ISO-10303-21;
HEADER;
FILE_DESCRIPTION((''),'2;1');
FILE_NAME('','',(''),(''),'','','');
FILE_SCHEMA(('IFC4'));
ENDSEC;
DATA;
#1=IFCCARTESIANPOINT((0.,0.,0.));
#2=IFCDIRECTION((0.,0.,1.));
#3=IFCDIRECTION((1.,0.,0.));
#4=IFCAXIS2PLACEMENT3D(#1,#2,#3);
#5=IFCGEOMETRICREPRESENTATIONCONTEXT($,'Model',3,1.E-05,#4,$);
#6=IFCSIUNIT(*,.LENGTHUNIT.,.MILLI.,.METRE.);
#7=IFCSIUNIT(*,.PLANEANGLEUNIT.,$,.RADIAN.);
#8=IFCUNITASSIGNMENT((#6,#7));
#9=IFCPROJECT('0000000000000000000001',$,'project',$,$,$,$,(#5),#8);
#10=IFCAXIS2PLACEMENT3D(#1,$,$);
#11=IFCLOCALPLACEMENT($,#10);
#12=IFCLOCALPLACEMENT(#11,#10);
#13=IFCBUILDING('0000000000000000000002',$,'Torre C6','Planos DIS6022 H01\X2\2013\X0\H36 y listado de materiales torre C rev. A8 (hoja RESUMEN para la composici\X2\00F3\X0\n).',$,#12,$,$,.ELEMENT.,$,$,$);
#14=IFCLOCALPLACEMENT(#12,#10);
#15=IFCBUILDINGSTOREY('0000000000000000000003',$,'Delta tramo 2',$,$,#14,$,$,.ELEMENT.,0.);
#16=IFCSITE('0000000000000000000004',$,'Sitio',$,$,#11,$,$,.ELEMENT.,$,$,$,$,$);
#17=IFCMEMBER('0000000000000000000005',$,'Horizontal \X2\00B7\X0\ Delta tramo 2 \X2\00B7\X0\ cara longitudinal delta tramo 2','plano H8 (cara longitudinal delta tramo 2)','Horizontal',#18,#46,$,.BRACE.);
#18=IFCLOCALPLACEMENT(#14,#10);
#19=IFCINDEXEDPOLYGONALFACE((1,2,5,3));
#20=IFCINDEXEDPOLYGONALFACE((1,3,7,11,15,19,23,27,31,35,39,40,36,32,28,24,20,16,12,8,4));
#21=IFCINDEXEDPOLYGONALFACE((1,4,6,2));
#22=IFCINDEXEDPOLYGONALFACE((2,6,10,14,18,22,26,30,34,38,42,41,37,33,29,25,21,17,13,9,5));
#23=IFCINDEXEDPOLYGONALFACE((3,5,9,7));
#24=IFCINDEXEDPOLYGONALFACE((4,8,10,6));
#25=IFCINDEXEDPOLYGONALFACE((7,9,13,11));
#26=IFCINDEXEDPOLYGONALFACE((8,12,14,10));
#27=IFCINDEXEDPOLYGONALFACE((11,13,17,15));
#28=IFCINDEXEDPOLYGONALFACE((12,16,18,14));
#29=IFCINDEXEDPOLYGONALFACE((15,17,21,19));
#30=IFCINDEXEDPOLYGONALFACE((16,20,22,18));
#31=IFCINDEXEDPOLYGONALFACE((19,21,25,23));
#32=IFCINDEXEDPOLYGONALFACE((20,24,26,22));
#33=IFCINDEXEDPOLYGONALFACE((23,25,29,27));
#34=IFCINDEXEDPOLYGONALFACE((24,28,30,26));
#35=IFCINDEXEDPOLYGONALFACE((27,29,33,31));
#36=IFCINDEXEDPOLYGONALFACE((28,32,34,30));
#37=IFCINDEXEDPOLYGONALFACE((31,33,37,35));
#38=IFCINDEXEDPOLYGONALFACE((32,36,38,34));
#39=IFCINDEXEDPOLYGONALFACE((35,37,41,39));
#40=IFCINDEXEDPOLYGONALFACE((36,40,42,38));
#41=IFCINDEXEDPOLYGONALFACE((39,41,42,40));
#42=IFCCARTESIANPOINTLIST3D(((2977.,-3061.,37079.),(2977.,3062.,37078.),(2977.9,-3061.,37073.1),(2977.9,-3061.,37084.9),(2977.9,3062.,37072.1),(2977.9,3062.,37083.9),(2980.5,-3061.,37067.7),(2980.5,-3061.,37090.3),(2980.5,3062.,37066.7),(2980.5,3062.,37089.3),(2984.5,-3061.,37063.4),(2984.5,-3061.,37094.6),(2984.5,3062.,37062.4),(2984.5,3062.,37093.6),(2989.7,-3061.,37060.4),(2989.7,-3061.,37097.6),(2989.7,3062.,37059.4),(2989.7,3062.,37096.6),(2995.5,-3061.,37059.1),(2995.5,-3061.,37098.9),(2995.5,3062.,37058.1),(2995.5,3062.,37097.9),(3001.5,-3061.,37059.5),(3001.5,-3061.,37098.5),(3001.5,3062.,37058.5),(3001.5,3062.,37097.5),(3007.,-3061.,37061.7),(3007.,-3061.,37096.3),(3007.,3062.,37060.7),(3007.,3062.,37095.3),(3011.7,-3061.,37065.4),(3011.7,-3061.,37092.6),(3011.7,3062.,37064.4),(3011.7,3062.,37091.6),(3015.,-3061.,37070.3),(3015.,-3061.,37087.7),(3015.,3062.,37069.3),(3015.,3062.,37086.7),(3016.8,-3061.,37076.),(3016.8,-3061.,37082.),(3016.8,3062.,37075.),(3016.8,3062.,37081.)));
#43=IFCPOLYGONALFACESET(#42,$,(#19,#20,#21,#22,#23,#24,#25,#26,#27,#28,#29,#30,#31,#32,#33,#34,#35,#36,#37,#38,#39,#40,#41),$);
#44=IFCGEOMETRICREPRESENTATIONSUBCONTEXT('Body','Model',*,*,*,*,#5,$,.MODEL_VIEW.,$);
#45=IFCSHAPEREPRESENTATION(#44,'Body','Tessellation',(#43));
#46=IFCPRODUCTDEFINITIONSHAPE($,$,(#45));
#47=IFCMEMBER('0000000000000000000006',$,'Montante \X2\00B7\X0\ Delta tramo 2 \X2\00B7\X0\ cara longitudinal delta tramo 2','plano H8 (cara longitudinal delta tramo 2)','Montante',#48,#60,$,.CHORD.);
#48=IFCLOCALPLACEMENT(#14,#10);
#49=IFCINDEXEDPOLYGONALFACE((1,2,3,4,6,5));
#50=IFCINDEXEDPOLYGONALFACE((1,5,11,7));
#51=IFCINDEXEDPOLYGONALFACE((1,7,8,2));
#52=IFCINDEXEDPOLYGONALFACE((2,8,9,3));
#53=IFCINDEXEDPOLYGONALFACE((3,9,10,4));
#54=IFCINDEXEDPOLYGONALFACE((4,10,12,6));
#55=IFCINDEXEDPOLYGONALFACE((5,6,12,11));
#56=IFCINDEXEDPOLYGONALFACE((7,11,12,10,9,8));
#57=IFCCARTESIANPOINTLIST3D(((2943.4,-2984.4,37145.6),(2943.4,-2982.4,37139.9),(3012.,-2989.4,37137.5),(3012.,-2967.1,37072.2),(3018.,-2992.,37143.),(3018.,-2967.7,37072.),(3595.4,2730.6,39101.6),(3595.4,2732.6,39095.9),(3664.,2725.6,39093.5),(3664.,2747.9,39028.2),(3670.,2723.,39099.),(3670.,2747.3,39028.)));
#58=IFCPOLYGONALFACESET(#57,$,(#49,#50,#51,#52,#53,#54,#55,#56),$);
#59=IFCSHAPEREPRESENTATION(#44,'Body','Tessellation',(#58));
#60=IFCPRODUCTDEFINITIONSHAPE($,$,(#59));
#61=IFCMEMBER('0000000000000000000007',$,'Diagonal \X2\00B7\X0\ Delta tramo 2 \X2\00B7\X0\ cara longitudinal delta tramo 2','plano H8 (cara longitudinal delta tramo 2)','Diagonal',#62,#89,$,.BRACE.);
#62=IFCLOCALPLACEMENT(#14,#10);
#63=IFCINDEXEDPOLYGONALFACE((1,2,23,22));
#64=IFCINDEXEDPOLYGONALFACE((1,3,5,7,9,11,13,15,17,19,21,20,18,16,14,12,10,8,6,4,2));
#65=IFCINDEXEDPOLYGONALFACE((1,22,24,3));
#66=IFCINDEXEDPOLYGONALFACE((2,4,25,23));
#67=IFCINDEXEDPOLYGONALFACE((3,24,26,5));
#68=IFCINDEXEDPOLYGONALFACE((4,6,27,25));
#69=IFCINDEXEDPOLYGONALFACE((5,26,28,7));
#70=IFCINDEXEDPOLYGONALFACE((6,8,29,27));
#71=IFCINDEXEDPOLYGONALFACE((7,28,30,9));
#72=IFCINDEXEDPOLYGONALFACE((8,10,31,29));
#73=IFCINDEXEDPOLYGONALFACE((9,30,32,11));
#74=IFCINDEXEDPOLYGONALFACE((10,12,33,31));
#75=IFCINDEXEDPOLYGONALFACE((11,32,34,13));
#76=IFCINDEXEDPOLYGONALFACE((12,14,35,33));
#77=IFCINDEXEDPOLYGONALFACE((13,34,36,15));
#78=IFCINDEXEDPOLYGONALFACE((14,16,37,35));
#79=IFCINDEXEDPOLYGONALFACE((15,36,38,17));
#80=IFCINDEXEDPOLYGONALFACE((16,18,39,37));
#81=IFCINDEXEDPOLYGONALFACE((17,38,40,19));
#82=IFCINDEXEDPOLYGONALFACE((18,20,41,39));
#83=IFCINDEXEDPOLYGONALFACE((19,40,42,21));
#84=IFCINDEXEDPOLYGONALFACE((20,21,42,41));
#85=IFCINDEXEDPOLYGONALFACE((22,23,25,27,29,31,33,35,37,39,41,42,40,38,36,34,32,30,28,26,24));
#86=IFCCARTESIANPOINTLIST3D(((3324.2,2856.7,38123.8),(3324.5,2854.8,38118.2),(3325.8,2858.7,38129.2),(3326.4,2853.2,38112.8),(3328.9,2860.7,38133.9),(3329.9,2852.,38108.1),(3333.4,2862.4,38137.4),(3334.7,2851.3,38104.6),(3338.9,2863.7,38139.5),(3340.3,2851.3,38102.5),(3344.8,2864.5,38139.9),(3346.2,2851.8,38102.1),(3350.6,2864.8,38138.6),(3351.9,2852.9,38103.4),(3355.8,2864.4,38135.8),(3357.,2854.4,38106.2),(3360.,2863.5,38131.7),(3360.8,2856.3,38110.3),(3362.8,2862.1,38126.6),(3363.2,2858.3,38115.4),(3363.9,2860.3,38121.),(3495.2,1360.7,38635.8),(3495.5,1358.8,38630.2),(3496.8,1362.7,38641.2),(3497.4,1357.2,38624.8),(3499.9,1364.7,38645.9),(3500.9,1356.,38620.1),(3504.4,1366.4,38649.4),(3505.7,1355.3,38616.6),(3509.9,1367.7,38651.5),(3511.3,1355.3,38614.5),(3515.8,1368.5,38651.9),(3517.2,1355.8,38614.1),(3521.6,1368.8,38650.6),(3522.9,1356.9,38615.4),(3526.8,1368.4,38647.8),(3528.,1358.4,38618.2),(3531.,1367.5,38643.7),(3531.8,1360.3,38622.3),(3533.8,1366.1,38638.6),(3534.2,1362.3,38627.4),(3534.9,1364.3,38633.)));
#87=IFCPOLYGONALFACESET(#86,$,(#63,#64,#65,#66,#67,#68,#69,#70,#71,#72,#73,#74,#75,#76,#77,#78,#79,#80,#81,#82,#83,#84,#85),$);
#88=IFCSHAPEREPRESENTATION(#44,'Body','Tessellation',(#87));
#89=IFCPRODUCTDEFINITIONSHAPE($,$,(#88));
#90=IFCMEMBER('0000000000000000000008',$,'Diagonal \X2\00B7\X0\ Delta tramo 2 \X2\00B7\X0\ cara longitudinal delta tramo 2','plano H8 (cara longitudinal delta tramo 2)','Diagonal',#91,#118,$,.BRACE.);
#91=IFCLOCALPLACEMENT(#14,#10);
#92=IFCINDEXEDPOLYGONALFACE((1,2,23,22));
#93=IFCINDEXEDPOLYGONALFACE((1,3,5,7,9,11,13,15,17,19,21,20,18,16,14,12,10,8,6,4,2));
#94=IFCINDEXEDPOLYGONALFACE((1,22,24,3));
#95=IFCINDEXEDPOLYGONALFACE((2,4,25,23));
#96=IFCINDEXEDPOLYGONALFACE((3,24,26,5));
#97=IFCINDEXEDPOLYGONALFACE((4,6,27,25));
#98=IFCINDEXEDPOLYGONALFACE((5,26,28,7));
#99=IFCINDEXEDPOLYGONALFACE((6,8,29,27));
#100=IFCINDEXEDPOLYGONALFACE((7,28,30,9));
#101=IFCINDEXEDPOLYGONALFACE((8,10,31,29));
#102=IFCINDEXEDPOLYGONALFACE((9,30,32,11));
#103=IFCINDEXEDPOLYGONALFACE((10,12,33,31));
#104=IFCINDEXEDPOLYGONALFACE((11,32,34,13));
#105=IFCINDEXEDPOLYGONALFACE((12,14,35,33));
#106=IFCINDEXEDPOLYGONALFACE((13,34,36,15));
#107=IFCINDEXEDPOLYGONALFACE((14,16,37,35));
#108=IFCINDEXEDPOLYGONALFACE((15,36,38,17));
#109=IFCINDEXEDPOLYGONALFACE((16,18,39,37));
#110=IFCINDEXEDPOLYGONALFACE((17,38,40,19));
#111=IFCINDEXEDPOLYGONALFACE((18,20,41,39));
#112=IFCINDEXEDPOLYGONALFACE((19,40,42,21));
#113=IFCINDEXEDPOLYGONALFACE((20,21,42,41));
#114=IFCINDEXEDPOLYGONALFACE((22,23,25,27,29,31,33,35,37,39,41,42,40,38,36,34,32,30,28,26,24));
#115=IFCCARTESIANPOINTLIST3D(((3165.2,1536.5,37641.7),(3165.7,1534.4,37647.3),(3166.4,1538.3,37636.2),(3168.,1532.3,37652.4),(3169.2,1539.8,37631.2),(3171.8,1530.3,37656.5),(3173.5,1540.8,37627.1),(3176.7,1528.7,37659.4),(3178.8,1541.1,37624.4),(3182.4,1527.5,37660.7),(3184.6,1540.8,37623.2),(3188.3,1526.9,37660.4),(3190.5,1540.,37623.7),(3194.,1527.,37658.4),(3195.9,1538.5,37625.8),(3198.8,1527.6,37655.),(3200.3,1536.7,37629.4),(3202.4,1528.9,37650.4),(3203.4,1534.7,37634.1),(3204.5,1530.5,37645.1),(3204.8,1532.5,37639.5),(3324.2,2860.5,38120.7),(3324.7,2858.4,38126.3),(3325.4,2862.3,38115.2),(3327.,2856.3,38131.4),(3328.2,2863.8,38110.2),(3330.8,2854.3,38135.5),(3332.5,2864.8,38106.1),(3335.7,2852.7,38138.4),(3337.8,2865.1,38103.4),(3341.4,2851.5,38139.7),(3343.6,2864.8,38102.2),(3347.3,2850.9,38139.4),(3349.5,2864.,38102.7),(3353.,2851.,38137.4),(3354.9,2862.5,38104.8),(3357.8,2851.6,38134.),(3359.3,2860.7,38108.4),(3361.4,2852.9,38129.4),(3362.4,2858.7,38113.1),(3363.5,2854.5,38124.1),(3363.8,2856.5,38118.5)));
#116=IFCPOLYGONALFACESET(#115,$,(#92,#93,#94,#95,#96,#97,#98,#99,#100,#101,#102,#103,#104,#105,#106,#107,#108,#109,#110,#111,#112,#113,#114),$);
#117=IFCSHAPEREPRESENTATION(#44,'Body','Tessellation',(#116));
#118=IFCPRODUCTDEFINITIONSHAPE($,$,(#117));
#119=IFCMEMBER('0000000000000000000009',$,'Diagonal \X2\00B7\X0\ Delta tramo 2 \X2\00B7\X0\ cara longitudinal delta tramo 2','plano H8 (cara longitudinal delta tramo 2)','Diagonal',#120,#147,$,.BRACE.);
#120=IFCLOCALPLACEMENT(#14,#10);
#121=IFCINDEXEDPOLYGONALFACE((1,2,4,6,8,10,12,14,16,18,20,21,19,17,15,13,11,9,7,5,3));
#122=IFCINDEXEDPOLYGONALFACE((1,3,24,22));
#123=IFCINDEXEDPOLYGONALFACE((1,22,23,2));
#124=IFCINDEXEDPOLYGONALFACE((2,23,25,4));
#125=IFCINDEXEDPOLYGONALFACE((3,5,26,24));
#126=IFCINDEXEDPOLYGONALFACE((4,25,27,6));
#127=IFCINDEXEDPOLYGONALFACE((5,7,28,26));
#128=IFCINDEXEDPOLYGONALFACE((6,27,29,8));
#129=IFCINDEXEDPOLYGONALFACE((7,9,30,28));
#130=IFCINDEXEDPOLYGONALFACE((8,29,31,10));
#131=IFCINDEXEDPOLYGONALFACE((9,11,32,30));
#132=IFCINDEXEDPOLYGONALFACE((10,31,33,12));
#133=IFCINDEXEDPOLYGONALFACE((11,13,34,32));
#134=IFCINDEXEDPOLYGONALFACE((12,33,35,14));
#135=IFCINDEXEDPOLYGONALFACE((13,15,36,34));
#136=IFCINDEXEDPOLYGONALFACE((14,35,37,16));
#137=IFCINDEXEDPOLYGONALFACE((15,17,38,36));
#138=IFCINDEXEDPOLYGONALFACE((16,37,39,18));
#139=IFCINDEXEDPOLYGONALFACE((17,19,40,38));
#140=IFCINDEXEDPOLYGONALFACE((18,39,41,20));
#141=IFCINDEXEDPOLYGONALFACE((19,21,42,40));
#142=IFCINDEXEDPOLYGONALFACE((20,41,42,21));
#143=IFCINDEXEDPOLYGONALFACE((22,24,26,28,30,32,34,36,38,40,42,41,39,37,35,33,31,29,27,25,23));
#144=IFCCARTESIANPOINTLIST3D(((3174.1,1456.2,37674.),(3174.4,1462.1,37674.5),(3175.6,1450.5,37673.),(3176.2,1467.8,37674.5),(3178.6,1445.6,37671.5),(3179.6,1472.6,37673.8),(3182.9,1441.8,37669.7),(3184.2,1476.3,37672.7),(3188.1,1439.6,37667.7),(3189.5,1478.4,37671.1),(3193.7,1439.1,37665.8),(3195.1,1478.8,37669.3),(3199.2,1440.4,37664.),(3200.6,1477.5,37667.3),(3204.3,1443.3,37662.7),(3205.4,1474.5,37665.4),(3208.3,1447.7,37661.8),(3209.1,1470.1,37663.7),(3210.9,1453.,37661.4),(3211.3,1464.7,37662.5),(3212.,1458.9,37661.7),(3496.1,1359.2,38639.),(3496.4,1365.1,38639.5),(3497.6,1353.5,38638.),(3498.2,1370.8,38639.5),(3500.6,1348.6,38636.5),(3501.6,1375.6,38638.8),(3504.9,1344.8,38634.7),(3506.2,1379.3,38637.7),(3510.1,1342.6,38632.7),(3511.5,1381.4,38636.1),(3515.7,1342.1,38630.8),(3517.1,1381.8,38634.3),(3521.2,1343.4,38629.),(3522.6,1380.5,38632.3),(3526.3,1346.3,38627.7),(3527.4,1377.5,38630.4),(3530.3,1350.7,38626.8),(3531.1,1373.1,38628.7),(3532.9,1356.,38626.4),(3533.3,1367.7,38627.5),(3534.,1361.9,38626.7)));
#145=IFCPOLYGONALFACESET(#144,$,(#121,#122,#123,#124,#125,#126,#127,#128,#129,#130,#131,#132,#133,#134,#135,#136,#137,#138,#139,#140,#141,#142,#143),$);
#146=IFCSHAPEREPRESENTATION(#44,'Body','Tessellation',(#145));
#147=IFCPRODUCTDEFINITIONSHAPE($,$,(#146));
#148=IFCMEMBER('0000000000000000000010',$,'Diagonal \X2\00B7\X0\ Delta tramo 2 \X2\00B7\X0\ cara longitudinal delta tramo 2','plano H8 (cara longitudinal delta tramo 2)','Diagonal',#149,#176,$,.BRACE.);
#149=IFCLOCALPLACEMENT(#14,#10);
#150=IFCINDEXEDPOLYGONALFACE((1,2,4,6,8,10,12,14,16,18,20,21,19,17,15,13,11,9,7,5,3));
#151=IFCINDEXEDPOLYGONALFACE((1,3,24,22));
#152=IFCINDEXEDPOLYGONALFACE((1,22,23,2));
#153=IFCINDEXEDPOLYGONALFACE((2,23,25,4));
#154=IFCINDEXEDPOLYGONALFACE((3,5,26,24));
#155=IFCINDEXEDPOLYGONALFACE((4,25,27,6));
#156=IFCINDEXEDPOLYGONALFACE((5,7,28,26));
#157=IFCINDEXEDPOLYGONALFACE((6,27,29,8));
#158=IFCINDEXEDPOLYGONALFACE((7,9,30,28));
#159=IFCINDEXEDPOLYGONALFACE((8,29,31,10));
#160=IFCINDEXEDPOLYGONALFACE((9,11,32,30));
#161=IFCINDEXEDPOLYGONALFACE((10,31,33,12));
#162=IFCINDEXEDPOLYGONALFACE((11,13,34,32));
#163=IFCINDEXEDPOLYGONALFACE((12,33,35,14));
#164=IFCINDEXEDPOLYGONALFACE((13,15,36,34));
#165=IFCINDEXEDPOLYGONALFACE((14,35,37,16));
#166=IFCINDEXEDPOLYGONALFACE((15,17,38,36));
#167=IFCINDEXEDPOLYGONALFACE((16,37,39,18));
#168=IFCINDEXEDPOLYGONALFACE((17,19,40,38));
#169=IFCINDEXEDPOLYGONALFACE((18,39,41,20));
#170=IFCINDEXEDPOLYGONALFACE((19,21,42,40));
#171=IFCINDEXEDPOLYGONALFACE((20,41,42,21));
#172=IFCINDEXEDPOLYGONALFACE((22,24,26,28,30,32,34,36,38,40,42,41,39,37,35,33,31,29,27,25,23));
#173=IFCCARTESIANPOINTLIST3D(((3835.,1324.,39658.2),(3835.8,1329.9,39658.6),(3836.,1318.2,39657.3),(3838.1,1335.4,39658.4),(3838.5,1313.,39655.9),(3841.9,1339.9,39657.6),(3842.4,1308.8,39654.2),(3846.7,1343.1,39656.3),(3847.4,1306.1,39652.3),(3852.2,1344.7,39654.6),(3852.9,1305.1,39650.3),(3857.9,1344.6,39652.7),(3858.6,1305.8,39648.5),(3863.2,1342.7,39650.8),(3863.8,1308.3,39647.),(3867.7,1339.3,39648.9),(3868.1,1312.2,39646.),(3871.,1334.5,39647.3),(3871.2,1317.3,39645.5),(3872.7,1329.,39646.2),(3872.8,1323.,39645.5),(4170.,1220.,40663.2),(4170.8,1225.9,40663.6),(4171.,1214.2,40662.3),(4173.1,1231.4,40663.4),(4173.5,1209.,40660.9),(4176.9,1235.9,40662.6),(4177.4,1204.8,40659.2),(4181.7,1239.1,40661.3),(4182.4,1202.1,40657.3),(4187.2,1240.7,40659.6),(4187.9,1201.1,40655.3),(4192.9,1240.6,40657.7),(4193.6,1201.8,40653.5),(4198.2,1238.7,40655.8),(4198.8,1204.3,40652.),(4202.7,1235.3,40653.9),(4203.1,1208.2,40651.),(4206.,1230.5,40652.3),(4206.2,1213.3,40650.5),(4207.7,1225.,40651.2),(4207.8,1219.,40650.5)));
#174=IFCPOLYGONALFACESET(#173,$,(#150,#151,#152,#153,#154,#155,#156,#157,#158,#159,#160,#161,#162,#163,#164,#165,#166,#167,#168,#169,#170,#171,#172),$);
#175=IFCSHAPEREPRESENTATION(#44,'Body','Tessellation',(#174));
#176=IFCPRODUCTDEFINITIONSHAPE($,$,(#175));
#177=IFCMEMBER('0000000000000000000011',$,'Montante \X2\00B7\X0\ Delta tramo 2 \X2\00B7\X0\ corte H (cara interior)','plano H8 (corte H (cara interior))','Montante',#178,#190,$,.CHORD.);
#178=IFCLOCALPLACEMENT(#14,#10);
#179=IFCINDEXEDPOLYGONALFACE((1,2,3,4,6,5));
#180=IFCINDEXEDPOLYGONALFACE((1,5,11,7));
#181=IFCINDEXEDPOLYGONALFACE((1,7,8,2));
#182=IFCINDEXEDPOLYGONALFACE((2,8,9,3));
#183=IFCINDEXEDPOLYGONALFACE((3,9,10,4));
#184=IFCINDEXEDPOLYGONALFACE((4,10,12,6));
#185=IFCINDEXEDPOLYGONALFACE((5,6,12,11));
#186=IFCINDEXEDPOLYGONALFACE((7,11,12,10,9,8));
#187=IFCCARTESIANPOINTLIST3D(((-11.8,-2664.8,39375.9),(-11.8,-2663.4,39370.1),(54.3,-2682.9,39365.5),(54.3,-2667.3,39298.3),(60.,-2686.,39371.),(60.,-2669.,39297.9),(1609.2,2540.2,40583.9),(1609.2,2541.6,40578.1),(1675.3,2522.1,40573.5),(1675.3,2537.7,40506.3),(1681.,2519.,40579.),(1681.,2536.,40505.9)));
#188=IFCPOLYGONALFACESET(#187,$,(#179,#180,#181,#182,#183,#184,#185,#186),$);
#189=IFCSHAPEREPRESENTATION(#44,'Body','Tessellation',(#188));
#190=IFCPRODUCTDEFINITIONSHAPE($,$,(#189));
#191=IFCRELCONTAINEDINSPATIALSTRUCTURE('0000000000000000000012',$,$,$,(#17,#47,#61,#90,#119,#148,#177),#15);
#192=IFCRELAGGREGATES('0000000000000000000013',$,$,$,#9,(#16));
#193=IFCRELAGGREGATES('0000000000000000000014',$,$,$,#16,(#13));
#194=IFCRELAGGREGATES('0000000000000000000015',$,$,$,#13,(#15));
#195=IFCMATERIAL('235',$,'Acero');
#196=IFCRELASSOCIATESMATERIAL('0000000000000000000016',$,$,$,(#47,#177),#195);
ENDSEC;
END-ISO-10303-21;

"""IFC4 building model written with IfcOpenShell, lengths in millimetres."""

from ifc_helpers import new_model, si_unit, frame, frame_2d, origin, origin_with_axes, place, context, subcontext, project, spatial, circle, l_section, extrude, material, element, save


model = new_model("IFC4")

# Units and contexts
model_context = context("Model", 3, precision=1e-05, world=origin_with_axes())
body_context = subcontext(model_context, "Body", "Model", "MODEL_VIEW")
ifc_project = project(units=[si_unit("LENGTHUNIT", "METRE", prefix="MILLI"), si_unit("PLANEANGLEUNIT", "RADIAN")], contexts=[model_context])

# Site, building, storey
site_placement = place(None, origin())
site = spatial("IfcSite", under=ifc_project, at=site_placement, Name="Sitio", CompositionType="ELEMENT")
building_placement = place(site_placement, origin())
building = spatial("IfcBuilding", under=site, at=building_placement, Name="Torre C6", Description="Planos DIS6022 H01–H36 y listado de materiales torre C rev. A8 (hoja RESUMEN para la composición).", CompositionType="ELEMENT")
storey_placement = place(building_placement, origin())
storey = spatial("IfcBuildingStorey", under=building, at=storey_placement, Name="Delta tramo 2", CompositionType="ELEMENT", Elevation=0.0)

# Members
member_1_placement = place(storey_placement, frame((2997.0, 3062.0, 37078.0), z_axis=(0.0, -1.0, 0.000163), x_axis=(-1.0, 0.0, 0.0)))
element("IfcMember", 1, at=member_1_placement, inside=storey, Name="Horizontal · Delta tramo 2 · cara longitudinal delta tramo 2", Description="plano H8 (cara longitudinal delta tramo 2)", ObjectType="Horizontal", PredefinedType="BRACE", context=body_context, shape_type="SweptSolid", body=[
    extrude(circle(Radius=20.0), None, (0.0, 0.0, 1.0), 6123.0),
])
ifc_material_1 = material(Name="235", Category="Acero")
member_2_placement = place(storey_placement, frame((3670.0, 2723.0, 39099.0), z_axis=(-0.107315, -0.940656, -0.321946), x_axis=(-0.994225, 0.101533, 0.034751)))
element("IfcMember", 2, at=member_2_placement, inside=storey, material=ifc_material_1, Name="Montante · Delta tramo 2 · cara longitudinal delta tramo 2", Description="plano H8 (cara longitudinal delta tramo 2)", ObjectType="Montante", PredefinedType="CHORD", context=body_context, shape_type="SweptSolid", body=[
    extrude(l_section(Depth=75.0, Width=75.0, Thickness=6.0, at=frame_2d((37.5, 37.5))), None, (0.0, 0.0, 1.0), 6075.5),
])
member_3_placement = place(storey_placement, frame((3515.0, 1362.0, 38633.0), z_axis=(-0.10752, 0.940639, -0.32193), x_axis=(-0.976994, -0.159952, -0.141059)))
element("IfcMember", 3, at=member_3_placement, inside=storey, Name="Diagonal · Delta tramo 2 · cara longitudinal delta tramo 2", Description="plano H8 (cara longitudinal delta tramo 2)", ObjectType="Diagonal", PredefinedType="BRACE", context=body_context, shape_type="SweptSolid", body=[
    extrude(circle(Radius=20.0), None, (0.0, 0.0, 1.0), 1590.4),
])
member_4_placement = place(storey_placement, frame((3344.0, 2858.0, 38121.0), z_axis=(-0.112214, -0.934413, -0.338054), x_axis=(-0.964462, 0.020521, 0.263423)))
element("IfcMember", 4, at=member_4_placement, inside=storey, Name="Diagonal · Delta tramo 2 · cara longitudinal delta tramo 2", Description="plano H8 (cara longitudinal delta tramo 2)", ObjectType="Diagonal", PredefinedType="BRACE", context=body_context, shape_type="SweptSolid", body=[
    extrude(circle(Radius=20.0), None, (0.0, 0.0, 1.0), 1416.9),
])
member_5_placement = place(storey_placement, frame((3515.0, 1362.0, 38633.0), z_axis=(-0.315094, 0.094919, -0.944302), x_axis=(-0.870343, -0.425656, 0.247629)))
element("IfcMember", 5, at=member_5_placement, inside=storey, Name="Diagonal · Delta tramo 2 · cara longitudinal delta tramo 2", Description="plano H8 (cara longitudinal delta tramo 2)", ObjectType="Diagonal", PredefinedType="BRACE", context=body_context, shape_type="SweptSolid", body=[
    extrude(circle(Radius=20.0), None, (0.0, 0.0, 1.0), 1021.9),
])
member_6_placement = place(storey_placement, frame((3854.0, 1325.0, 39652.0), z_axis=(0.314715, -0.097703, 0.944144), x_axis=(-0.901862, -0.340939, 0.26534)))
element("IfcMember", 6, at=member_6_placement, inside=storey, Name="Diagonal · Delta tramo 2 · cara longitudinal delta tramo 2", Description="plano H8 (cara longitudinal delta tramo 2)", ObjectType="Diagonal", PredefinedType="BRACE", context=body_context, shape_type="SweptSolid", body=[
    extrude(circle(Radius=20.0), None, (0.0, 0.0, 1.0), 1064.5),
])
member_7_placement = place(storey_placement, frame((1681.0, 2519.0, 40579.0), z_axis=(-0.290304, -0.932159, -0.21634), x_axis=(-0.956935, 0.282788, 0.065631)))
element("IfcMember", 7, at=member_7_placement, inside=storey, material=ifc_material_1, Name="Montante · Delta tramo 2 · corte H (cara interior)", Description="plano H8 (corte H (cara interior))", ObjectType="Montante", PredefinedType="CHORD", context=body_context, shape_type="SweptSolid", body=[
    extrude(l_section(Depth=75.0, Width=75.0, Thickness=6.0, at=frame_2d((37.5, 37.5))), None, (0.0, 0.0, 1.0), 5583.8),
])

save(model, "model.ifc")
